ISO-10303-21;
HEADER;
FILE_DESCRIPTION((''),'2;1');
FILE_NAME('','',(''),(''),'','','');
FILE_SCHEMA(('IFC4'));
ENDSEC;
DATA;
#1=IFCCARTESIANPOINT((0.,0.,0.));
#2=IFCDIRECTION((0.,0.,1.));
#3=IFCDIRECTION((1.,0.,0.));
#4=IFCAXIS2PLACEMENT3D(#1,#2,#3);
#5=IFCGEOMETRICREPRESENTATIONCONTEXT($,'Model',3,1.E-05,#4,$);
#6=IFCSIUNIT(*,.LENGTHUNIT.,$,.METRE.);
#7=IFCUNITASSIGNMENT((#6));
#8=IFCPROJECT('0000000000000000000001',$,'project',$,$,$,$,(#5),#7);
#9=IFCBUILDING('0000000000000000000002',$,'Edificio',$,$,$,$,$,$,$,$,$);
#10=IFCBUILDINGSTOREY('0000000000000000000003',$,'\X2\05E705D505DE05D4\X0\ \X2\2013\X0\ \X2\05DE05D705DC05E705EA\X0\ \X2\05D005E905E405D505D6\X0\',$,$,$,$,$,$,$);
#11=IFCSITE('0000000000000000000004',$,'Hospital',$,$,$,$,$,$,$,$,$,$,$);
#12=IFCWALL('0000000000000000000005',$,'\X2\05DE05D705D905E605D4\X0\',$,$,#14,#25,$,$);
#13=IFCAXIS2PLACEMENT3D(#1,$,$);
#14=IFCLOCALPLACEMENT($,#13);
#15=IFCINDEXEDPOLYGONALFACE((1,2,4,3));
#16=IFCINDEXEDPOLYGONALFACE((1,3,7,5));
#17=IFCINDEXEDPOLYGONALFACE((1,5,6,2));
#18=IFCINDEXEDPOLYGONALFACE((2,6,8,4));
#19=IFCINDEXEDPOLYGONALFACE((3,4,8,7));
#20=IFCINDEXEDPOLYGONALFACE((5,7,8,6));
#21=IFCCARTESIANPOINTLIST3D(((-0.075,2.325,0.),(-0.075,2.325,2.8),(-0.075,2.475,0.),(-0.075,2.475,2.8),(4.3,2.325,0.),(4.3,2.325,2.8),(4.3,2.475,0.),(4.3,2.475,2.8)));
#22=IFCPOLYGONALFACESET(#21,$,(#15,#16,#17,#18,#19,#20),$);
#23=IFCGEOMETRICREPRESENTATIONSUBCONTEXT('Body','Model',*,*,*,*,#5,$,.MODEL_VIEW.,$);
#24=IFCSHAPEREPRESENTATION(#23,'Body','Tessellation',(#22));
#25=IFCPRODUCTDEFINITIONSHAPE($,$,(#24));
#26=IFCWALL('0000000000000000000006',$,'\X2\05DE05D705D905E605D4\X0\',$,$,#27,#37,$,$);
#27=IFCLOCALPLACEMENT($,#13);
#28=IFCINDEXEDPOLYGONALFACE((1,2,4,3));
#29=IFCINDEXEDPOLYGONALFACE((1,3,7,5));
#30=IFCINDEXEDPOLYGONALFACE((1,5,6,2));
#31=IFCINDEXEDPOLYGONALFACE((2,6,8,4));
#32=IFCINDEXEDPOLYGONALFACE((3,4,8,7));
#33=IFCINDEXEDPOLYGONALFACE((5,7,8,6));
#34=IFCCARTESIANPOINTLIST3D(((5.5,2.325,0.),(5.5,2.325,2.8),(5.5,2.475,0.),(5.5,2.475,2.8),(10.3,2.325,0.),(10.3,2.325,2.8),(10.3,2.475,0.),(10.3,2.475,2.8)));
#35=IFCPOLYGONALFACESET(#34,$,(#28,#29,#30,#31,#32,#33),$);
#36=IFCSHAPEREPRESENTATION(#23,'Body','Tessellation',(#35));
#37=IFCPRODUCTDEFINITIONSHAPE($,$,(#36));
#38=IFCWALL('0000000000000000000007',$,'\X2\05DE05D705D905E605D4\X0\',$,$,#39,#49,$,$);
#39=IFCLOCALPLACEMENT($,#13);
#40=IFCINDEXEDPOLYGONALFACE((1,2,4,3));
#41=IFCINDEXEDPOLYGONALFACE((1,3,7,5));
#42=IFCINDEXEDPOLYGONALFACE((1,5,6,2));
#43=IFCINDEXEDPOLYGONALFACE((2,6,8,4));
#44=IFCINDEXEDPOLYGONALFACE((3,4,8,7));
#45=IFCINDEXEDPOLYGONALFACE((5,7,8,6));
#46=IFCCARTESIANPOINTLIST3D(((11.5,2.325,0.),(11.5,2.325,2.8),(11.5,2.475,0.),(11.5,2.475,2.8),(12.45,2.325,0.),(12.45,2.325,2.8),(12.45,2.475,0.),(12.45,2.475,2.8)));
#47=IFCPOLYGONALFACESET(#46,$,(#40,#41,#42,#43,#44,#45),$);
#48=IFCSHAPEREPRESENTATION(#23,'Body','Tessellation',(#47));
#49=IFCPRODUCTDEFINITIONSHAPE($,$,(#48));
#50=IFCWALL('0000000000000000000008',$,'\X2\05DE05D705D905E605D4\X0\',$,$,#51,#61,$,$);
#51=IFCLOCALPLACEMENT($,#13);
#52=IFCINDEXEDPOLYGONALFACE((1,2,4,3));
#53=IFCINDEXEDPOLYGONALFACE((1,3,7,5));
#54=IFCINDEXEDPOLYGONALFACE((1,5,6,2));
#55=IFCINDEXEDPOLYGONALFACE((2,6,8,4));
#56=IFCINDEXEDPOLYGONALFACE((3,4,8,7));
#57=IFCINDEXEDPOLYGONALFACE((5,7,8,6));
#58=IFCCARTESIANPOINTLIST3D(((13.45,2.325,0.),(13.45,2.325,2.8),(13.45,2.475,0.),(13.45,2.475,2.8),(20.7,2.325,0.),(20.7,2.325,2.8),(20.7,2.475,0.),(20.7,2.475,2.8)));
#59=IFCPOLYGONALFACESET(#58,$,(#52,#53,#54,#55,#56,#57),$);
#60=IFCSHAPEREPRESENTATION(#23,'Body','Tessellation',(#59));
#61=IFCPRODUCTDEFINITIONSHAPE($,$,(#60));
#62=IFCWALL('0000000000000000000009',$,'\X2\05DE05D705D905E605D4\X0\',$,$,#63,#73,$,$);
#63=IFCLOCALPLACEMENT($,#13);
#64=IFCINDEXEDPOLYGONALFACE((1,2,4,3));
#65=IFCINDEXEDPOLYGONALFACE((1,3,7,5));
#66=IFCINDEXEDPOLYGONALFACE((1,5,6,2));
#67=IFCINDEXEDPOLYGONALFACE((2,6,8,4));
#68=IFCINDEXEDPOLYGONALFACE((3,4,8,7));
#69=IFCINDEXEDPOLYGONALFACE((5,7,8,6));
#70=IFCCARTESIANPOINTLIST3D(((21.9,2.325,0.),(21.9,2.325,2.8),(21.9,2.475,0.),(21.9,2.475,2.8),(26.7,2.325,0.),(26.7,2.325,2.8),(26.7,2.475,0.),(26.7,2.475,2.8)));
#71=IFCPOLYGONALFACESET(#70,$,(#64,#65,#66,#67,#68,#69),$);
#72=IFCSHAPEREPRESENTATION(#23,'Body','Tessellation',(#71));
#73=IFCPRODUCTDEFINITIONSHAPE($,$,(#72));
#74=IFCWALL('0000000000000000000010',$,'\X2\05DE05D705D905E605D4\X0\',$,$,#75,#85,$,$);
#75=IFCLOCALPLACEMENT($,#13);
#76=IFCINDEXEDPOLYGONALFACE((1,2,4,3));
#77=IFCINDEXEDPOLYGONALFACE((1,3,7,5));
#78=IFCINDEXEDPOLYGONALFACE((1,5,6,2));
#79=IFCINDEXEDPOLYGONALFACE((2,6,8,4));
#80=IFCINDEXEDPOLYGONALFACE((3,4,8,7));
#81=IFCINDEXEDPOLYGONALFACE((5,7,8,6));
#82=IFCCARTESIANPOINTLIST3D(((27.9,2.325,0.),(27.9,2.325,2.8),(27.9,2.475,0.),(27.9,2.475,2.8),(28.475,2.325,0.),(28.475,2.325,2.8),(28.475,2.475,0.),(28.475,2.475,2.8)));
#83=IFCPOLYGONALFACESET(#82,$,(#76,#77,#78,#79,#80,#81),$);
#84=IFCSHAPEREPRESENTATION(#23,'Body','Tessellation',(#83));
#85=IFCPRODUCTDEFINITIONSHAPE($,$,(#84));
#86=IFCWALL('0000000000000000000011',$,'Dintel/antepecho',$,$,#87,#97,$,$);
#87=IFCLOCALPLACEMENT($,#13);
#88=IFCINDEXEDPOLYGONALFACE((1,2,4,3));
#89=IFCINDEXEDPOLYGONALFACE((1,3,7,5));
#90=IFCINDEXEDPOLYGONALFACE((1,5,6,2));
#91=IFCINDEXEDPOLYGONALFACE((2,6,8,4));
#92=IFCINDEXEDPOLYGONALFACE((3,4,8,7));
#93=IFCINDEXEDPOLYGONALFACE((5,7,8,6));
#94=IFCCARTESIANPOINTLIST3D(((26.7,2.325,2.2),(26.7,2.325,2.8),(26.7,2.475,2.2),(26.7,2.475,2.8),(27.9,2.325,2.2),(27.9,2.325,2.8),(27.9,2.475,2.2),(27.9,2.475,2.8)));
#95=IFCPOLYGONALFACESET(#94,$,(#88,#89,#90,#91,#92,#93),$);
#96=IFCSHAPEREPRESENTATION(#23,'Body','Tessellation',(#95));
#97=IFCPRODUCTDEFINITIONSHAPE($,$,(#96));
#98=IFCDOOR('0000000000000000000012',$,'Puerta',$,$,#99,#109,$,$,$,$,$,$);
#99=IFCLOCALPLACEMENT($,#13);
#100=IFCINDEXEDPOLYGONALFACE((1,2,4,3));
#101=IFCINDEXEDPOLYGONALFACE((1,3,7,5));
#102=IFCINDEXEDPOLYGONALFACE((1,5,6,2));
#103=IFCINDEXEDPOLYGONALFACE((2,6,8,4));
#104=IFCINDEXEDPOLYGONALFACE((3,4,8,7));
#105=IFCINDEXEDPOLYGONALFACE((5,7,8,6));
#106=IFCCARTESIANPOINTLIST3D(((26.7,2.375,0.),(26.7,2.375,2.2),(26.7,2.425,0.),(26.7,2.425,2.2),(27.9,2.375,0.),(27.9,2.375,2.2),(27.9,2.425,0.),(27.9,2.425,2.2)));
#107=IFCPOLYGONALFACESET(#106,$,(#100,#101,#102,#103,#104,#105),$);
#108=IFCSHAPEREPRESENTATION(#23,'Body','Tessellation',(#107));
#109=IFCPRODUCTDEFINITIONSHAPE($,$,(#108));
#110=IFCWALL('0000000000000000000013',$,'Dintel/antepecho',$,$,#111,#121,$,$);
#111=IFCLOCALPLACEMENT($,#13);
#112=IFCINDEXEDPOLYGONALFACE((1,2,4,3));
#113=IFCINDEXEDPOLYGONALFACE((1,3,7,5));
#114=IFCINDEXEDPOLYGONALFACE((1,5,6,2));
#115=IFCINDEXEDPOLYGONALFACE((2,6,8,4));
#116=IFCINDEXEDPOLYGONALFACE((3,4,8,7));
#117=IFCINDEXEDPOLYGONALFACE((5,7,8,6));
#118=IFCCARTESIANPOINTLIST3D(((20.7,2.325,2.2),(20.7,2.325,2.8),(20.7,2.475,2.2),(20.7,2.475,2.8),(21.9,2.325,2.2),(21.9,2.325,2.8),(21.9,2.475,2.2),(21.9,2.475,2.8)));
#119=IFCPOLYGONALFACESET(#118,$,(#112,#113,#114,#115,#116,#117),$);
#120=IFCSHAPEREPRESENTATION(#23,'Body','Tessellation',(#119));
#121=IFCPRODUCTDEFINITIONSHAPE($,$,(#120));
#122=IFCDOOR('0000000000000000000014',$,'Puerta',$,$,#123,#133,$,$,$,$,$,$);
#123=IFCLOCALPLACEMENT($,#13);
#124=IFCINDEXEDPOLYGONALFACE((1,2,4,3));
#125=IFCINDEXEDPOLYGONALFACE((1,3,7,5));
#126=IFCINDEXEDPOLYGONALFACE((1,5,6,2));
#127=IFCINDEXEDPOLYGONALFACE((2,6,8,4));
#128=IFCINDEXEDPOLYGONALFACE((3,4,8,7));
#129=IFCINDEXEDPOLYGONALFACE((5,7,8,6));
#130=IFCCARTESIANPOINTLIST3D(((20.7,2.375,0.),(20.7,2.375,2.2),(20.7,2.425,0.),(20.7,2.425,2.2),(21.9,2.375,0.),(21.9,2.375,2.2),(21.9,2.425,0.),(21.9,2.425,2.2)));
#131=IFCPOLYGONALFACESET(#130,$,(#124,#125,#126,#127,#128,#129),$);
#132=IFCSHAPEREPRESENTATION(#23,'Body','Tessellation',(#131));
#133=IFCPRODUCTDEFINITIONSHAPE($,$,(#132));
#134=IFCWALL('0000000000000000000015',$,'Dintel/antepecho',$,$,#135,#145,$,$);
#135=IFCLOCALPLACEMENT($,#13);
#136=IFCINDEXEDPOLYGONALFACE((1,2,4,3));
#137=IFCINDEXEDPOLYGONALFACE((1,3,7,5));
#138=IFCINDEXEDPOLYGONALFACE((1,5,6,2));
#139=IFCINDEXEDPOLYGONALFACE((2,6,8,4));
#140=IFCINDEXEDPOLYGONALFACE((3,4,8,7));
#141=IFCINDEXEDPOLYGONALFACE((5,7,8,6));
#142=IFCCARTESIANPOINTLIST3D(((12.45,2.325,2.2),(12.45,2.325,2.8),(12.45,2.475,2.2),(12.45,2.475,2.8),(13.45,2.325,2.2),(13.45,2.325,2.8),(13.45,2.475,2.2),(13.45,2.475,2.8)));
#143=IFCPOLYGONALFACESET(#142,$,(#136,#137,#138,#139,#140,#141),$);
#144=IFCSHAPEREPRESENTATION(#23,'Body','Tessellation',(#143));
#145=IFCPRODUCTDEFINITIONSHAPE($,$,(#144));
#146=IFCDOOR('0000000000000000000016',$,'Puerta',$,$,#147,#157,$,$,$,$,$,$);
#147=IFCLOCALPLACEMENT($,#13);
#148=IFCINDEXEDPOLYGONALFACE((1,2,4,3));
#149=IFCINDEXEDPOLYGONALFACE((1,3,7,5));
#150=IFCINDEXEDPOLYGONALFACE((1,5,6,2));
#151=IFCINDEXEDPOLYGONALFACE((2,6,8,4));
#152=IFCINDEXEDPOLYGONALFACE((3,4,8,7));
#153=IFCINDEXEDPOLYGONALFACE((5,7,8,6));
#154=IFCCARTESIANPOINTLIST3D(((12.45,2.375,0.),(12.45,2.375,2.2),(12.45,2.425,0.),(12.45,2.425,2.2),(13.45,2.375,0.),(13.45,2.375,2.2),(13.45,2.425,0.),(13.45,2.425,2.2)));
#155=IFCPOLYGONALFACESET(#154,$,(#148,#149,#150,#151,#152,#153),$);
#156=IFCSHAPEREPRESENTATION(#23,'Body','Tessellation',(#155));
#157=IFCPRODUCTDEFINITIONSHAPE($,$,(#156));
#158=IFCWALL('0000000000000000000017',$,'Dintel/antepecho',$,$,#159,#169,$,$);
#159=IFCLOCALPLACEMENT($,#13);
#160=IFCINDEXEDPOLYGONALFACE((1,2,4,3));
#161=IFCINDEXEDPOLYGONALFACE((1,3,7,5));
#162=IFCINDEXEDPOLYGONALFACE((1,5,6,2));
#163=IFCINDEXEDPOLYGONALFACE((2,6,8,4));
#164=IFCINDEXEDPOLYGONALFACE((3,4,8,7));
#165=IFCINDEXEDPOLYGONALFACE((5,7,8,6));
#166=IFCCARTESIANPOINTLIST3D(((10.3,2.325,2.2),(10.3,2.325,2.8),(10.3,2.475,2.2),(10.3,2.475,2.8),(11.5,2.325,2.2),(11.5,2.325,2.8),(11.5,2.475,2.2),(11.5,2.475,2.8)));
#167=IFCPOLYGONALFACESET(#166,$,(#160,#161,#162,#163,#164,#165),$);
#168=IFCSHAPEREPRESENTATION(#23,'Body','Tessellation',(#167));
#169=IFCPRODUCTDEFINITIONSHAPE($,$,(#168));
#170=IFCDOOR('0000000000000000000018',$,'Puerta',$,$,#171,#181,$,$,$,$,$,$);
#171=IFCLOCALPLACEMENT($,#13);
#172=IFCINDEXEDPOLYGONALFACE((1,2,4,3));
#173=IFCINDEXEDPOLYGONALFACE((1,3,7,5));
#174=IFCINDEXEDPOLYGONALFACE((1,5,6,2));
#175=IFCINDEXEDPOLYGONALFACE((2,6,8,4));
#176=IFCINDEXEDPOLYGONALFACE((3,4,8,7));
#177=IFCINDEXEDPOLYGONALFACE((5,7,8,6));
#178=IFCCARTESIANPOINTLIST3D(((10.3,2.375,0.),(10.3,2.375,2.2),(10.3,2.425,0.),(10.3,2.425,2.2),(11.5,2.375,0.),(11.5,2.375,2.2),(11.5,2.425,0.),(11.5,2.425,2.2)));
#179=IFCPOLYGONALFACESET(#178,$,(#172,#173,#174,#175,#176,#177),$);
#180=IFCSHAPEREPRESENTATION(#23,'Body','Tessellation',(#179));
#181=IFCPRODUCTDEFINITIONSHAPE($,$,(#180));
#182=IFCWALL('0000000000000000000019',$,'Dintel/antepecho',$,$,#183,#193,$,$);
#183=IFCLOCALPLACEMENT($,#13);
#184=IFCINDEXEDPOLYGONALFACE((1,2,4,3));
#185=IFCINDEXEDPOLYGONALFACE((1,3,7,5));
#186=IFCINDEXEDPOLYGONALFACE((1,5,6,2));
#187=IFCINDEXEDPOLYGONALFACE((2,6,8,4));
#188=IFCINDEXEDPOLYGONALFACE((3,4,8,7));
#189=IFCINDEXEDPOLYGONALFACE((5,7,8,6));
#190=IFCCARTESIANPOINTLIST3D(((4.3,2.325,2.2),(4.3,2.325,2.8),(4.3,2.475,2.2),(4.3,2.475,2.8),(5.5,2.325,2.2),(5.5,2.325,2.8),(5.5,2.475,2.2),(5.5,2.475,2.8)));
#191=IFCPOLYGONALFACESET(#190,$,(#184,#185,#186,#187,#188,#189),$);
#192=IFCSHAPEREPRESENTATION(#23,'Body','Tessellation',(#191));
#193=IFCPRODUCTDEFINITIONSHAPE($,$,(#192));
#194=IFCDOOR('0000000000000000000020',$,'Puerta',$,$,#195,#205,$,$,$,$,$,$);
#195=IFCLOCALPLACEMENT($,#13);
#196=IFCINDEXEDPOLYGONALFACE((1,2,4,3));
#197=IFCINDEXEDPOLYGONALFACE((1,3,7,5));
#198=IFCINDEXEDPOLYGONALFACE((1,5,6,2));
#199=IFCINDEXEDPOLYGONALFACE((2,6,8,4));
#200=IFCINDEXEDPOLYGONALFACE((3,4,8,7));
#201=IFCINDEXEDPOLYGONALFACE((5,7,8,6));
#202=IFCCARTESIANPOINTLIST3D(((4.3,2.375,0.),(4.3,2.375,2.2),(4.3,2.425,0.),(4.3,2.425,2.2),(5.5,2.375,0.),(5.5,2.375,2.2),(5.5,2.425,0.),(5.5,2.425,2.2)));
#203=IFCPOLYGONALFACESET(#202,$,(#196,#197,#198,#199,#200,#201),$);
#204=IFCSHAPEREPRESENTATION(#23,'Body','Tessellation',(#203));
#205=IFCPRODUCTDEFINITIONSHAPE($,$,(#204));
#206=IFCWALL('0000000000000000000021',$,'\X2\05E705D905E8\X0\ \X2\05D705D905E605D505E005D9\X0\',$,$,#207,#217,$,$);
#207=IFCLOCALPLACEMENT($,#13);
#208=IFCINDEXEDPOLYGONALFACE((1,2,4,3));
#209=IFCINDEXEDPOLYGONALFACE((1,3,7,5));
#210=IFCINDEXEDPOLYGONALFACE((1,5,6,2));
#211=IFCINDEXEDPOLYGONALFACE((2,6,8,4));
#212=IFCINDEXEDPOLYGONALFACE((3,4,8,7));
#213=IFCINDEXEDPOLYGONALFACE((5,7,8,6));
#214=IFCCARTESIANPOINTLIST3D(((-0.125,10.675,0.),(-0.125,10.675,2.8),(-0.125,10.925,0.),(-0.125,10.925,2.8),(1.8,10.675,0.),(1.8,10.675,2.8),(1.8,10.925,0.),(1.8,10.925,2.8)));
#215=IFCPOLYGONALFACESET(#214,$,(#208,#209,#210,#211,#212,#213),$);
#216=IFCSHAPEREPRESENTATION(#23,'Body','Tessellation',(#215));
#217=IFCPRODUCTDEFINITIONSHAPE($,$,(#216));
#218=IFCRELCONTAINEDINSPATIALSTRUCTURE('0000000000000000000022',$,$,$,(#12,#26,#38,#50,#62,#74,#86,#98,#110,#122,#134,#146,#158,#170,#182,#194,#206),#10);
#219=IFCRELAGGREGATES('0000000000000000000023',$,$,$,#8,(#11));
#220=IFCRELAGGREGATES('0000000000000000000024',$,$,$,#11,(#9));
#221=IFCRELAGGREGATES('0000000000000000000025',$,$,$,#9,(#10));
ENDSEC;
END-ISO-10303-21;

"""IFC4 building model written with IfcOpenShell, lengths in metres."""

from ifc_helpers import new_model, si_unit, frame, origin_with_axes, context, subcontext, project, spatial, line, indexed_curve, outline, extrude, element, save


model = new_model("IFC4")

# Units and contexts
model_context = context("Model", 3, precision=1e-05, world=origin_with_axes())
body_context = subcontext(model_context, "Body", "Model", "MODEL_VIEW")
ifc_project = project(units=[si_unit("LENGTHUNIT", "METRE")], contexts=[model_context])

# Site, building, storey
site = spatial("IfcSite", under=ifc_project, Name="Hospital")
building = spatial("IfcBuilding", under=site, Name="Edificio")
storey = spatial("IfcBuildingStorey", under=building, Name="קומה – מחלקת אשפוז")

# Walls
element("IfcWall", 1, inside=storey, Name="מחיצה", context=body_context, shape_type="SweptSolid", body=[
    extrude(outline(indexed_curve([(0.0, 0.0), (4.375, 0.0), (4.375, 0.15), (0.0, 0.15)], segments=[line(1, 2, 3, 4, 1)])), frame((-0.075, 2.325, 0.0), z_axis=(0.0, 0.0, 1.0), x_axis=(1.0, 0.0, 0.0)), (0.0, 0.0, 1.0), 2.8),
])
element("IfcWall", 2, inside=storey, Name="מחיצה", context=body_context, shape_type="SweptSolid", body=[
    extrude(outline(indexed_curve([(0.0, 0.0), (4.8, 0.0), (4.8, 0.15), (0.0, 0.15)], segments=[line(1, 2, 3, 4, 1)])), frame((5.5, 2.325, 0.0), z_axis=(0.0, 0.0, 1.0), x_axis=(1.0, 0.0, 0.0)), (0.0, 0.0, 1.0), 2.8),
])
element("IfcWall", 3, inside=storey, Name="מחיצה", context=body_context, shape_type="SweptSolid", body=[
    extrude(outline(indexed_curve([(0.0, 0.0), (0.95, 0.0), (0.95, 0.15), (0.0, 0.15)], segments=[line(1, 2, 3, 4, 1)])), frame((11.5, 2.325, 0.0), z_axis=(0.0, 0.0, 1.0), x_axis=(1.0, 0.0, 0.0)), (0.0, 0.0, 1.0), 2.8),
])
element("IfcWall", 4, inside=storey, Name="מחיצה", context=body_context, shape_type="SweptSolid", body=[
    extrude(outline(indexed_curve([(0.0, 0.0), (7.25, 0.0), (7.25, 0.15), (0.0, 0.15)], segments=[line(1, 2, 3, 4, 1)])), frame((13.45, 2.325, 0.0), z_axis=(0.0, 0.0, 1.0), x_axis=(1.0, 0.0, 0.0)), (0.0, 0.0, 1.0), 2.8),
])
element("IfcWall", 5, inside=storey, Name="מחיצה", context=body_context, shape_type="SweptSolid", body=[
    extrude(outline(indexed_curve([(0.0, 0.0), (4.8, 0.0), (4.8, 0.15), (0.0, 0.15)], segments=[line(1, 2, 3, 4, 1)])), frame((21.9, 2.325, 0.0), z_axis=(0.0, 0.0, 1.0), x_axis=(1.0, 0.0, 0.0)), (0.0, 0.0, 1.0), 2.8),
])
element("IfcWall", 6, inside=storey, Name="מחיצה", context=body_context, shape_type="SweptSolid", body=[
    extrude(outline(indexed_curve([(0.0, 0.0), (0.575, 0.0), (0.575, 0.15), (0.0, 0.15)], segments=[line(1, 2, 3, 4, 1)])), frame((27.9, 2.325, 0.0), z_axis=(0.0, 0.0, 1.0), x_axis=(1.0, 0.0, 0.0)), (0.0, 0.0, 1.0), 2.8),
])
element("IfcWall", 7, inside=storey, Name="Dintel/antepecho", context=body_context, shape_type="SweptSolid", body=[
    extrude(outline(indexed_curve([(0.0, 0.0), (1.2, 0.0), (1.2, 0.15), (0.0, 0.15)], segments=[line(1, 2, 3, 4, 1)])), frame((26.7, 2.325, 2.2), z_axis=(0.0, 0.0, 1.0), x_axis=(1.0, 0.0, 0.0)), (0.0, 0.0, 1.0), 0.6),
])

# Door
element("IfcDoor", 8, inside=storey, Name="Puerta", context=body_context, shape_type="SweptSolid", body=[
    extrude(outline(indexed_curve([(0.0, 0.0), (1.2, 0.0), (1.2, 0.05), (0.0, 0.05)], segments=[line(1, 2, 3, 4, 1)])), frame((26.7, 2.375, 0.0), z_axis=(0.0, 0.0, 1.0), x_axis=(1.0, 0.0, 0.0)), (0.0, 0.0, 1.0), 2.2),
])

# Wall
element("IfcWall", 9, inside=storey, Name="Dintel/antepecho", context=body_context, shape_type="SweptSolid", body=[
    extrude(outline(indexed_curve([(0.0, 0.0), (1.2, 0.0), (1.2, 0.15), (0.0, 0.15)], segments=[line(1, 2, 3, 4, 1)])), frame((20.7, 2.325, 2.2), z_axis=(0.0, 0.0, 1.0), x_axis=(1.0, 0.0, 0.0)), (0.0, 0.0, 1.0), 0.6),
])

# Door
element("IfcDoor", 10, inside=storey, Name="Puerta", context=body_context, shape_type="SweptSolid", body=[
    extrude(outline(indexed_curve([(0.0, 0.0), (1.2, 0.0), (1.2, 0.05), (0.0, 0.05)], segments=[line(1, 2, 3, 4, 1)])), frame((20.7, 2.375, 0.0), z_axis=(0.0, 0.0, 1.0), x_axis=(1.0, 0.0, 0.0)), (0.0, 0.0, 1.0), 2.2),
])

# Wall
element("IfcWall", 11, inside=storey, Name="Dintel/antepecho", context=body_context, shape_type="SweptSolid", body=[
    extrude(outline(indexed_curve([(0.0, 0.0), (1.0, 0.0), (1.0, 0.15), (0.0, 0.15)], segments=[line(1, 2, 3, 4, 1)])), frame((12.45, 2.325, 2.2), z_axis=(0.0, 0.0, 1.0), x_axis=(1.0, 0.0, 0.0)), (0.0, 0.0, 1.0), 0.6),
])

# Door
element("IfcDoor", 12, inside=storey, Name="Puerta", context=body_context, shape_type="SweptSolid", body=[
    extrude(outline(indexed_curve([(0.0, 0.0), (1.0, 0.0), (1.0, 0.05), (0.0, 0.05)], segments=[line(1, 2, 3, 4, 1)])), frame((12.45, 2.375, 0.0), z_axis=(0.0, 0.0, 1.0), x_axis=(1.0, 0.0, 0.0)), (0.0, 0.0, 1.0), 2.2),
])

# Wall
element("IfcWall", 13, inside=storey, Name="Dintel/antepecho", context=body_context, shape_type="SweptSolid", body=[
    extrude(outline(indexed_curve([(0.0, 0.0), (1.2, 0.0), (1.2, 0.15), (0.0, 0.15)], segments=[line(1, 2, 3, 4, 1)])), frame((10.3, 2.325, 2.2), z_axis=(0.0, 0.0, 1.0), x_axis=(1.0, 0.0, 0.0)), (0.0, 0.0, 1.0), 0.6),
])

# Door
element("IfcDoor", 14, inside=storey, Name="Puerta", context=body_context, shape_type="SweptSolid", body=[
    extrude(outline(indexed_curve([(0.0, 0.0), (1.2, 0.0), (1.2, 0.05), (0.0, 0.05)], segments=[line(1, 2, 3, 4, 1)])), frame((10.3, 2.375, 0.0), z_axis=(0.0, 0.0, 1.0), x_axis=(1.0, 0.0, 0.0)), (0.0, 0.0, 1.0), 2.2),
])

# Wall
element("IfcWall", 15, inside=storey, Name="Dintel/antepecho", context=body_context, shape_type="SweptSolid", body=[
    extrude(outline(indexed_curve([(0.0, 0.0), (1.2, 0.0), (1.2, 0.15), (0.0, 0.15)], segments=[line(1, 2, 3, 4, 1)])), frame((4.3, 2.325, 2.2), z_axis=(0.0, 0.0, 1.0), x_axis=(1.0, 0.0, 0.0)), (0.0, 0.0, 1.0), 0.6),
])

# Door
element("IfcDoor", 16, inside=storey, Name="Puerta", context=body_context, shape_type="SweptSolid", body=[
    extrude(outline(indexed_curve([(0.0, 0.0), (1.2, 0.0), (1.2, 0.05), (0.0, 0.05)], segments=[line(1, 2, 3, 4, 1)])), frame((4.3, 2.375, 0.0), z_axis=(0.0, 0.0, 1.0), x_axis=(1.0, 0.0, 0.0)), (0.0, 0.0, 1.0), 2.2),
])

# Wall
element("IfcWall", 17, inside=storey, Name="קיר חיצוני", context=body_context, shape_type="SweptSolid", body=[
    extrude(outline(indexed_curve([(0.0, 0.0), (1.925, 0.0), (1.925, 0.25), (0.0, 0.25)], segments=[line(1, 2, 3, 4, 1)])), frame((-0.125, 10.675, 0.0), z_axis=(0.0, 0.0, 1.0), x_axis=(1.0, 0.0, 0.0)), (0.0, 0.0, 1.0), 2.8),
])

save(model, "model.ifc")
